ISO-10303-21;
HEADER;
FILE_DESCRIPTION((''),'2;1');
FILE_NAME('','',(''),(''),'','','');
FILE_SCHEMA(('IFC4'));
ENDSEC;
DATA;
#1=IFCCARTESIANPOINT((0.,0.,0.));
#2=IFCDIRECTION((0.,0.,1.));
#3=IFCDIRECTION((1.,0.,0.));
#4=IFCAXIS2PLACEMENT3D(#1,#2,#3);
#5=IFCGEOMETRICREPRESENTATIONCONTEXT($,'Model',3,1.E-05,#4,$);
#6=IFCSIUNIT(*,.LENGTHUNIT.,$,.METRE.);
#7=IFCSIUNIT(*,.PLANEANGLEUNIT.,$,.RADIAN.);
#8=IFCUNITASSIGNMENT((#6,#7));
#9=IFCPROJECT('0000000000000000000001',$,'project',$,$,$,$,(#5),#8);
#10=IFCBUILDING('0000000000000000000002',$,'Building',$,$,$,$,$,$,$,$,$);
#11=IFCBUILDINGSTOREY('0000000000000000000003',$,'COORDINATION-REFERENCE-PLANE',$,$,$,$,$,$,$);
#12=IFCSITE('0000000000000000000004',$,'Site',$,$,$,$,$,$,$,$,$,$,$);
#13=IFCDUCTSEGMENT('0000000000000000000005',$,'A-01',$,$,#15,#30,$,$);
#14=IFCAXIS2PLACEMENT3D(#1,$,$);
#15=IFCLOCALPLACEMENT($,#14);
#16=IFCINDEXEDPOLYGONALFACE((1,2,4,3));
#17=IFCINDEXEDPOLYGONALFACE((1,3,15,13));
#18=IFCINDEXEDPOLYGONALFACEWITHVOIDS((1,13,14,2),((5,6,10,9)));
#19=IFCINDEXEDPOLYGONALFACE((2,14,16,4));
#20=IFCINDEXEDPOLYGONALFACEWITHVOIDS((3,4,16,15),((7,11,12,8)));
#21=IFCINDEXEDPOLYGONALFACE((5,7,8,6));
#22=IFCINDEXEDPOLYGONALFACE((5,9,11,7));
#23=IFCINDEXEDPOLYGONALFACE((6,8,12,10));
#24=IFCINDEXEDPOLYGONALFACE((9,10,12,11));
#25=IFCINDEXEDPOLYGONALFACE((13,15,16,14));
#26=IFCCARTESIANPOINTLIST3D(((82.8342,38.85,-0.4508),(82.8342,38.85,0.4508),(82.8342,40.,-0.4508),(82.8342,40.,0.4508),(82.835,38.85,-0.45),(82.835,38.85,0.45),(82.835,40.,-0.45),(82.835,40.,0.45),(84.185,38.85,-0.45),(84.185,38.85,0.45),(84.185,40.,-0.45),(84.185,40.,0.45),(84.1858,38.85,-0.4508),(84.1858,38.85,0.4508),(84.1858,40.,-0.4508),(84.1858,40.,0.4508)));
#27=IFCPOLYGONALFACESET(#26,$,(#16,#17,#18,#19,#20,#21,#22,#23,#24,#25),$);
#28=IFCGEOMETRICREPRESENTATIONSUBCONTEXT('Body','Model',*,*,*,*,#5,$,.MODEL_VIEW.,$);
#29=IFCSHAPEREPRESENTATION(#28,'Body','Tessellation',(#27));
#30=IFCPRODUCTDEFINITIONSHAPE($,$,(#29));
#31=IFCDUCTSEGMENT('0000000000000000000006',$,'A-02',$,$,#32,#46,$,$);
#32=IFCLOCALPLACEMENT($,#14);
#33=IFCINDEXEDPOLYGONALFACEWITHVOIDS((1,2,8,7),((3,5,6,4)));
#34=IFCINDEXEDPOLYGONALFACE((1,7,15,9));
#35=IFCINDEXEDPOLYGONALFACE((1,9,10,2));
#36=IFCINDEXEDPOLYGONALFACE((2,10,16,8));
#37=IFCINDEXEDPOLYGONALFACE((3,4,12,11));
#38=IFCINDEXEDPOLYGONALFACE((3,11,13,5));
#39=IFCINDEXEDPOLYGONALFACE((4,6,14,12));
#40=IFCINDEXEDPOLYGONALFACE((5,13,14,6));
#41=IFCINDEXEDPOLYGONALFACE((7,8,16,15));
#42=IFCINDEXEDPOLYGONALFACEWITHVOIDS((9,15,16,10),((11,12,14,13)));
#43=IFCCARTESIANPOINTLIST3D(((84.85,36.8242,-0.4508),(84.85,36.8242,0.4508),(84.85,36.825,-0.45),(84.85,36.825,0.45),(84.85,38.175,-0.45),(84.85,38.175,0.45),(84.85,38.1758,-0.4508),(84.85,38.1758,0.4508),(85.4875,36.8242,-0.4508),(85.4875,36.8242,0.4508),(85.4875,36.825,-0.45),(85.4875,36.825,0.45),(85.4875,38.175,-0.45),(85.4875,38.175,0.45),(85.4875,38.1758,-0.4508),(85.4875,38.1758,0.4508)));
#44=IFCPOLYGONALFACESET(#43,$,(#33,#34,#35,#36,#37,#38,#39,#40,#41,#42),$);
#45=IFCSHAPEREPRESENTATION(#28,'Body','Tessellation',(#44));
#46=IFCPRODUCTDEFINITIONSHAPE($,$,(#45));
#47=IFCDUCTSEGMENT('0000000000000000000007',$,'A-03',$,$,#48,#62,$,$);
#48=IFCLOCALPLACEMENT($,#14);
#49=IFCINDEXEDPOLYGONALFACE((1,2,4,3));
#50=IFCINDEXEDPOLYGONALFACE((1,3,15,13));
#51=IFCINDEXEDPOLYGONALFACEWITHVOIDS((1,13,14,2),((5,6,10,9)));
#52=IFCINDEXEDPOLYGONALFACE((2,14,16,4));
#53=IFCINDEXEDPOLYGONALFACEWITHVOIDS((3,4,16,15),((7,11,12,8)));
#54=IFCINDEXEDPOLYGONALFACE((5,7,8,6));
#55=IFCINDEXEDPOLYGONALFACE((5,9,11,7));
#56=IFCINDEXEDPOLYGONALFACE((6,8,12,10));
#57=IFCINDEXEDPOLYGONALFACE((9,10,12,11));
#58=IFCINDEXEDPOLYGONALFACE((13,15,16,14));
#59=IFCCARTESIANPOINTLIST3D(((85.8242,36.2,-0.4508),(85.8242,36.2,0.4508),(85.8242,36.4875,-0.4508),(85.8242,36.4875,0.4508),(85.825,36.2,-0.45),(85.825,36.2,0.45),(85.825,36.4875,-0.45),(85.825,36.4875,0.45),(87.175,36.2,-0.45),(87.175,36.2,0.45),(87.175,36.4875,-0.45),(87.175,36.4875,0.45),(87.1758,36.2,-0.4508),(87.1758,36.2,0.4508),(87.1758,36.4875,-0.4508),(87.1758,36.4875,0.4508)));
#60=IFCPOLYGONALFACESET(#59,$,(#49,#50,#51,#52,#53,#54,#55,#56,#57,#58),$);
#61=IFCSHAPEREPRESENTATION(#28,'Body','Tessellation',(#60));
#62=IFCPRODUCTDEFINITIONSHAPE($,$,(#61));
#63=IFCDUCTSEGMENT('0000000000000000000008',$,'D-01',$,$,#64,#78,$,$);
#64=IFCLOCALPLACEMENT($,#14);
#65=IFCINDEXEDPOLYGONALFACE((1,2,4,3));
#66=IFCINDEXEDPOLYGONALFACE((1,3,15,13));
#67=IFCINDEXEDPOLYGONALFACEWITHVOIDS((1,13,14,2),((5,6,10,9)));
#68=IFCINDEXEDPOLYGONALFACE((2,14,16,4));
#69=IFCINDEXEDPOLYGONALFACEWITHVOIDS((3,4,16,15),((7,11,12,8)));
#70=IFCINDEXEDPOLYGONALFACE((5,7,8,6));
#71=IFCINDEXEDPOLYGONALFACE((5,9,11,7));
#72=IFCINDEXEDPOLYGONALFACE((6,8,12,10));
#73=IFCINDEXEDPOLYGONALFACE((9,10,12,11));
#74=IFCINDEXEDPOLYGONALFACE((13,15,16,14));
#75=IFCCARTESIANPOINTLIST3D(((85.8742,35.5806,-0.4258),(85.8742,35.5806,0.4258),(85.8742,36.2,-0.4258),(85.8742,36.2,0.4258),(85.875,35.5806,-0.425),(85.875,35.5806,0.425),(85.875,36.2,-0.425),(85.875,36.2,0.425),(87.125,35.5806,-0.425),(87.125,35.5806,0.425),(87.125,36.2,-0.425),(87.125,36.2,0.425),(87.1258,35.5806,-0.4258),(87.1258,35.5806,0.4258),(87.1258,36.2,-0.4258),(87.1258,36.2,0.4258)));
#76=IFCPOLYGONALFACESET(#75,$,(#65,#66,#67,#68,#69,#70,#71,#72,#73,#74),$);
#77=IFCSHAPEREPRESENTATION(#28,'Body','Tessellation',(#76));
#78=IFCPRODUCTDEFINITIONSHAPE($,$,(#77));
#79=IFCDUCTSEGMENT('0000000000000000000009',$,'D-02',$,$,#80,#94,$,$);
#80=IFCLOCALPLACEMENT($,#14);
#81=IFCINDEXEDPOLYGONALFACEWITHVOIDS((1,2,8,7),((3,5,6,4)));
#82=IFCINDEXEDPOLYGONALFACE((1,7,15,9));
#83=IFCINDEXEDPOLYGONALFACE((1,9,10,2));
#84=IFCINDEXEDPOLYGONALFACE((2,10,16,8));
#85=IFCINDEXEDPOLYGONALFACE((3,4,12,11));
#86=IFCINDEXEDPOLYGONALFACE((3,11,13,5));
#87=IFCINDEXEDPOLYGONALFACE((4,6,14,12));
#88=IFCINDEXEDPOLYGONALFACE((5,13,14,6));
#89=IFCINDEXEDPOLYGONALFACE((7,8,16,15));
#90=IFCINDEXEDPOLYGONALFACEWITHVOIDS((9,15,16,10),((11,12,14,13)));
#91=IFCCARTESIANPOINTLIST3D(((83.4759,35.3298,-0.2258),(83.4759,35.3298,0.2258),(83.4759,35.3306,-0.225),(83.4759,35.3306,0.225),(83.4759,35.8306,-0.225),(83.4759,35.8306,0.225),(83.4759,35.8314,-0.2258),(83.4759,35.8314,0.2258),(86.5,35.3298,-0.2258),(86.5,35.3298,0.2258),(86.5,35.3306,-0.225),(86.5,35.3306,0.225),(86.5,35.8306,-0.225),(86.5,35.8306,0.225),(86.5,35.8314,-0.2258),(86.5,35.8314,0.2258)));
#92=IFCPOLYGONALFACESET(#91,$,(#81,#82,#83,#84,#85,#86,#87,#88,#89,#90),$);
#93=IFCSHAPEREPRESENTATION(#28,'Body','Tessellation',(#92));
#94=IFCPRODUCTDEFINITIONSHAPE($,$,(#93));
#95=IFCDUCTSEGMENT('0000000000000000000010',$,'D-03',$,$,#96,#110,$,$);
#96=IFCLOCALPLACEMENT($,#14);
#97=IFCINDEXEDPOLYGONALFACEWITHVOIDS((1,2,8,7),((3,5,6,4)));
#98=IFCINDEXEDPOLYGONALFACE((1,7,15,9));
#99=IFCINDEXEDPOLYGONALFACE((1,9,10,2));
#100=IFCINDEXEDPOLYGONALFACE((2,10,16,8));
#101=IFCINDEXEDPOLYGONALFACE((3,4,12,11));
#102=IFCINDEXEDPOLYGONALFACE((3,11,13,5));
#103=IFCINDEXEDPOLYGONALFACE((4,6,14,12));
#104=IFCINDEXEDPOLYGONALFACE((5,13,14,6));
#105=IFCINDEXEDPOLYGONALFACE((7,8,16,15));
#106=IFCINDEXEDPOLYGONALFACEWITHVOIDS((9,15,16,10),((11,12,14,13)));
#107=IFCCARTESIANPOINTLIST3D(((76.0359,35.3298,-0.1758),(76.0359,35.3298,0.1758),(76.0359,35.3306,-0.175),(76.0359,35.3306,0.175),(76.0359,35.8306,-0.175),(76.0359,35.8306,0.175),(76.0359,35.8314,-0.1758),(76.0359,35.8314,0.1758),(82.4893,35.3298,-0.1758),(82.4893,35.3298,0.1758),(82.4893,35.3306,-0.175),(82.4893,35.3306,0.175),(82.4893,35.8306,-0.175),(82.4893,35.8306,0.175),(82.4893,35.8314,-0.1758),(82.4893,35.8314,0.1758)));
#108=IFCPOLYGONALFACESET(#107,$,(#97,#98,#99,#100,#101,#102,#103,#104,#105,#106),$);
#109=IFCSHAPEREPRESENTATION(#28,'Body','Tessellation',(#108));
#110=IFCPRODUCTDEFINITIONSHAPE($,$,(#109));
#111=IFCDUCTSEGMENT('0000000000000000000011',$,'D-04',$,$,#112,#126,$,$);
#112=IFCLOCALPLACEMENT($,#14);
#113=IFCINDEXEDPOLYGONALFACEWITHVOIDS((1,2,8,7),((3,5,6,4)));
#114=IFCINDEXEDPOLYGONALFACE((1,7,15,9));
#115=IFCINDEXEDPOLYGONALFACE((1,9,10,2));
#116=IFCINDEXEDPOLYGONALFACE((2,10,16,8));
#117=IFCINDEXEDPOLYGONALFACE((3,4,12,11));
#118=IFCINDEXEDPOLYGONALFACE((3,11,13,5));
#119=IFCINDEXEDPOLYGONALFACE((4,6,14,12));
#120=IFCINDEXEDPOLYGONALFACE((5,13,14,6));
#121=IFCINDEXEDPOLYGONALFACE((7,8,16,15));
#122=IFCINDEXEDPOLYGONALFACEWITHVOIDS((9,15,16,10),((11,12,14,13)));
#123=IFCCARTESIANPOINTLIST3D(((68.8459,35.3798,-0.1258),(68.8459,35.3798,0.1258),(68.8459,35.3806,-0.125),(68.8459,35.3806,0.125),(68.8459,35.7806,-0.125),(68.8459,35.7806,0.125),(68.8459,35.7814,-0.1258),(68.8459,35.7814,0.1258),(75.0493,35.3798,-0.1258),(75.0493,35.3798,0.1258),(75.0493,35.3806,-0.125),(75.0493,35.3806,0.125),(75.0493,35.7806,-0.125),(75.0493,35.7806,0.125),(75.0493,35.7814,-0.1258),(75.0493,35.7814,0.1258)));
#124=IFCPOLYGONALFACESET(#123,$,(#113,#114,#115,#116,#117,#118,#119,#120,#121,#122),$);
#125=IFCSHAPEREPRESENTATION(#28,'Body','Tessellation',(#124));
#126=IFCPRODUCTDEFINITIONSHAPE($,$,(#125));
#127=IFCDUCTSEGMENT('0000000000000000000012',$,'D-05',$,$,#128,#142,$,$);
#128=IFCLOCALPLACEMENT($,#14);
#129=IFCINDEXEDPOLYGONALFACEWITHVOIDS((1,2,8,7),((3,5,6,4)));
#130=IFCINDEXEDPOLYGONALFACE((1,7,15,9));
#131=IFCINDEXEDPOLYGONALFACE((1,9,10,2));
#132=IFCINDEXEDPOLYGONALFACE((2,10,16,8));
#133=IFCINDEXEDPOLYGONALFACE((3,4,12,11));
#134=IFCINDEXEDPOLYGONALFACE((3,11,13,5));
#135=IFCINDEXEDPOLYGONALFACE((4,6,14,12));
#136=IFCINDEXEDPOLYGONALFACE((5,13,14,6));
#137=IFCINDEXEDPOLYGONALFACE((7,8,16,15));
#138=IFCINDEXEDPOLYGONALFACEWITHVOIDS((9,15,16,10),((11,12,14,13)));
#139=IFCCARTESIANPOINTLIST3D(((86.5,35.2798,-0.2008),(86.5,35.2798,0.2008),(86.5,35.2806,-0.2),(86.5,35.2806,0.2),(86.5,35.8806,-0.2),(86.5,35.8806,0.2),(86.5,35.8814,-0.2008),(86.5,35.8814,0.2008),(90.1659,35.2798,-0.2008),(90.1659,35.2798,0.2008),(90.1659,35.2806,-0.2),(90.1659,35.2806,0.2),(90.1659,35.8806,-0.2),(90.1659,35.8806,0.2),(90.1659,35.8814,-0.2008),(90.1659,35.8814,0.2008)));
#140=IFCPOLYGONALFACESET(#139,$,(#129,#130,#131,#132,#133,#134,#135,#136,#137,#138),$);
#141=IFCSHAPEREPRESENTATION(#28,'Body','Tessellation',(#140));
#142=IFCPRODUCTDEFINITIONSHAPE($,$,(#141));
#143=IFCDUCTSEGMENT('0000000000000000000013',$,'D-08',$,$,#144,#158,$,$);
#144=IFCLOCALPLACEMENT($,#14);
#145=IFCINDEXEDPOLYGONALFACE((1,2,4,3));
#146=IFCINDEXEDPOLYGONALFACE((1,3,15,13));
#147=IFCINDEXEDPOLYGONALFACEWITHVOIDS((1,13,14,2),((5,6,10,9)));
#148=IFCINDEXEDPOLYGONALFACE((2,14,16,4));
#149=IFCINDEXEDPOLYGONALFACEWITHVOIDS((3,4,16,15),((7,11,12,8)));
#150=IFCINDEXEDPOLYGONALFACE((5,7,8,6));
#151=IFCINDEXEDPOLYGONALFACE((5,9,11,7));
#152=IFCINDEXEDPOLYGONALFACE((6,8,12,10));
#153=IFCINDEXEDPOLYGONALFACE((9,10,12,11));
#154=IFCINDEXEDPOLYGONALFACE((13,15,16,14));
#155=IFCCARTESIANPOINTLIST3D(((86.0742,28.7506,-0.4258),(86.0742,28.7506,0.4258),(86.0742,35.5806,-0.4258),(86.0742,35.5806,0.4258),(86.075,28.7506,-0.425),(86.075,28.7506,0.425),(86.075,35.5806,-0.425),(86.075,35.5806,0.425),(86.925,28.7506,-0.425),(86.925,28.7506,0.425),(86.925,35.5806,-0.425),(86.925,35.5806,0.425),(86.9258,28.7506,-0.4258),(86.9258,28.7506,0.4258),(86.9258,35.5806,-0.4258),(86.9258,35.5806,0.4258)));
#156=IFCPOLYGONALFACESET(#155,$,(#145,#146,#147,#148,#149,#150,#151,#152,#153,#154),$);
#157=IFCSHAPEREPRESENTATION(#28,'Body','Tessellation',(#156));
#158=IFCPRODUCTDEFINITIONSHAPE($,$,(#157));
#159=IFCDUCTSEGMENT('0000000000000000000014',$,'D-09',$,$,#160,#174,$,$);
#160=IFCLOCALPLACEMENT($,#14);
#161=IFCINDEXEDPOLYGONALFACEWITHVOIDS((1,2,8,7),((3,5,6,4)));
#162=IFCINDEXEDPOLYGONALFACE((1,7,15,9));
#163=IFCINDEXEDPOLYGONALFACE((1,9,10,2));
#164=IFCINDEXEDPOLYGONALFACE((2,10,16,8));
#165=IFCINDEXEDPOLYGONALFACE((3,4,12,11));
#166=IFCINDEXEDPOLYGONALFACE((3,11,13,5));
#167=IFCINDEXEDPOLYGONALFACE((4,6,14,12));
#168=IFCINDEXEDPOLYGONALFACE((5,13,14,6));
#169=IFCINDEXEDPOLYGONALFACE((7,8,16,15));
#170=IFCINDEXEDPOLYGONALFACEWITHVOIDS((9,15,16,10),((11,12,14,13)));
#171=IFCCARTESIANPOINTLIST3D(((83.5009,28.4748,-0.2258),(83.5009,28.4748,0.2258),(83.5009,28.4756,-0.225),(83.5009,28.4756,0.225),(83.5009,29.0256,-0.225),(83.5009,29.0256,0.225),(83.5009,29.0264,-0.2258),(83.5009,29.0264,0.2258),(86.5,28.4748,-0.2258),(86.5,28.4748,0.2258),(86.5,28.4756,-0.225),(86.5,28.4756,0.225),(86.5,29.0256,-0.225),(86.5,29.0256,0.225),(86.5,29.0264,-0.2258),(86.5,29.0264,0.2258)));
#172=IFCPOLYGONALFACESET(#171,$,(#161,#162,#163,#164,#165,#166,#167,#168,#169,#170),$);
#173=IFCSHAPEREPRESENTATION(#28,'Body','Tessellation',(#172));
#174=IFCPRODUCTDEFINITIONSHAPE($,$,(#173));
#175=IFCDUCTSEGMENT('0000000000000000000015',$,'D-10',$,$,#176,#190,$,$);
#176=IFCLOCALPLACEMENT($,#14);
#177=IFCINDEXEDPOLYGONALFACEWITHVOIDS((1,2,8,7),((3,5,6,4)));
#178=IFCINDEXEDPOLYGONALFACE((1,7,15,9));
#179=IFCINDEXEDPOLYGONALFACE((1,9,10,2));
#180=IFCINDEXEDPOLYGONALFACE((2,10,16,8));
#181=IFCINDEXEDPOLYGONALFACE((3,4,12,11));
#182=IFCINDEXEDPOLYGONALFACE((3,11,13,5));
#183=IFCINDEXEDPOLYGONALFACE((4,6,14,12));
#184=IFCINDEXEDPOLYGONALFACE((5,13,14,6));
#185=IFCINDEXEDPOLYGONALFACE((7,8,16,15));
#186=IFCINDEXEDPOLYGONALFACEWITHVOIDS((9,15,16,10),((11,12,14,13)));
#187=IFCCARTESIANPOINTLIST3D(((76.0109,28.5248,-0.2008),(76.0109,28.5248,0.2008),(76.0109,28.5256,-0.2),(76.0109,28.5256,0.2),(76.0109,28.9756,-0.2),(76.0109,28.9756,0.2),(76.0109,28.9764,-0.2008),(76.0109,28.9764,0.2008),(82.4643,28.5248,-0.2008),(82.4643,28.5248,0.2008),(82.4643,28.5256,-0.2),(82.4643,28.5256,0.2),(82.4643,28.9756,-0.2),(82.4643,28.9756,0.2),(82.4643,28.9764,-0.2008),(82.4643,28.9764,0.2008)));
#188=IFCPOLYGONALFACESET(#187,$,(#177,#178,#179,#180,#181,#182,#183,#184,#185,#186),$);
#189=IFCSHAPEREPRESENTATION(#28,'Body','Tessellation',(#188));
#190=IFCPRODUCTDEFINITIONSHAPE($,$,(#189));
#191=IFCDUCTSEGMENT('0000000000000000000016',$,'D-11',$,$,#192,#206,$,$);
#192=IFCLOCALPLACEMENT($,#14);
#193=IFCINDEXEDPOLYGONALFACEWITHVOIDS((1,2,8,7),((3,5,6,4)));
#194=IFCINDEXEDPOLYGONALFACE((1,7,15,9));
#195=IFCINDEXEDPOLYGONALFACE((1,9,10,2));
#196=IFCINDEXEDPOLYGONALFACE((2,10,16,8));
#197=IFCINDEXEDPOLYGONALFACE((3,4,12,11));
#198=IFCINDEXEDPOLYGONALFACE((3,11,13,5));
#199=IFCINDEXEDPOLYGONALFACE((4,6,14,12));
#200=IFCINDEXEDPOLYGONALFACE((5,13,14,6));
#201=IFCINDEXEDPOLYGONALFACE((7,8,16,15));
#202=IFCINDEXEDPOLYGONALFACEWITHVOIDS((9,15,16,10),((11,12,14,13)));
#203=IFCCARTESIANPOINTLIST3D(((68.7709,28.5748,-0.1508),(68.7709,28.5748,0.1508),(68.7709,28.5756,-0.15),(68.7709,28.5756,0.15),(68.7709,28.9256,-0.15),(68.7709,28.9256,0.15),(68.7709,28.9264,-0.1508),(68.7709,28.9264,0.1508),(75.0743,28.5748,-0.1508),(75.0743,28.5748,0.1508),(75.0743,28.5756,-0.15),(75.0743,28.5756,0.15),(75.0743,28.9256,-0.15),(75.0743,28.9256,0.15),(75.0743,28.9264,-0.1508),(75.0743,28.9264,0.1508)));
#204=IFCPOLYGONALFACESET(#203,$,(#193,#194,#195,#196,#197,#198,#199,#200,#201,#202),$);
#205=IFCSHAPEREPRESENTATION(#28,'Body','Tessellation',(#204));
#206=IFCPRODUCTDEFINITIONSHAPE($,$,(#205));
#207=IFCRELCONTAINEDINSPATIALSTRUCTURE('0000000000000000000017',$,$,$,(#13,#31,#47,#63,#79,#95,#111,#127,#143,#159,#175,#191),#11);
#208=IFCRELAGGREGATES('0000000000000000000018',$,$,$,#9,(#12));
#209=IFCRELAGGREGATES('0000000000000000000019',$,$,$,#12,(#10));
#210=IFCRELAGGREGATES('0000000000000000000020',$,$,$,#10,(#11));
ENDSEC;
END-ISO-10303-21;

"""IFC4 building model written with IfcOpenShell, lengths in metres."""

from ifc_helpers import new_model, si_unit, frame, origin, origin_with_axes, place, context, subcontext, project, spatial, hollow_rectangle, extrude, element, save


model = new_model("IFC4")

# Units and contexts
model_context = context("Model", 3, precision=1e-05, world=origin_with_axes())
body_context = subcontext(model_context, "Body", "Model", "MODEL_VIEW")
ifc_project = project(units=[si_unit("LENGTHUNIT", "METRE"), si_unit("PLANEANGLEUNIT", "RADIAN")], contexts=[model_context])

# Site, building, storey
site = spatial("IfcSite", under=ifc_project, Name="Site")
building = spatial("IfcBuilding", under=site, Name="Building")
storey = spatial("IfcBuildingStorey", under=building, Name="COORDINATION-REFERENCE-PLANE")

# Duct segments
duct_segment_1_placement = place(None, frame((83.51, 38.85, 0.0), z_axis=(0.0, 1.0, 0.0), x_axis=(1.0, 0.0, 0.0)))
element("IfcDuctSegment", 1, at=duct_segment_1_placement, inside=storey, Name="A-01", context=body_context, shape_type="SweptSolid", body=[
    extrude(hollow_rectangle(XDim=1.3516, YDim=0.9016, WallThickness=0.0008), origin(), (0.0, 0.0, 1.0), 1.15),
])
duct_segment_2_placement = place(None, frame((84.85, 37.5, 0.0), z_axis=(1.0, 0.0, 0.0), x_axis=(0.0, 1.0, 0.0)))
element("IfcDuctSegment", 2, at=duct_segment_2_placement, inside=storey, Name="A-02", context=body_context, shape_type="SweptSolid", body=[
    extrude(hollow_rectangle(XDim=1.3516, YDim=0.9016, WallThickness=0.0008), origin(), (0.0, 0.0, 1.0), 0.6375),
])
duct_segment_3_placement = place(None, frame((86.5, 36.2, 0.0), z_axis=(0.0, 1.0, 0.0), x_axis=(1.0, 0.0, 0.0)))
element("IfcDuctSegment", 3, at=duct_segment_3_placement, inside=storey, Name="A-03", context=body_context, shape_type="SweptSolid", body=[
    extrude(hollow_rectangle(XDim=1.3516, YDim=0.9016, WallThickness=0.0008), origin(), (0.0, 0.0, 1.0), 0.2875),
])
duct_segment_4_placement = place(None, frame((86.5, 35.5806, 0.0), z_axis=(0.0, 1.0, 0.0), x_axis=(1.0, 0.0, 0.0)))
element("IfcDuctSegment", 4, at=duct_segment_4_placement, inside=storey, Name="D-01", context=body_context, shape_type="SweptSolid", body=[
    extrude(hollow_rectangle(XDim=1.2516, YDim=0.8516, WallThickness=0.0008), origin(), (0.0, 0.0, 1.0), 0.6194),
])
duct_segment_5_placement = place(None, frame((83.4759, 35.5806, 0.0), z_axis=(1.0, 0.0, 0.0), x_axis=(0.0, 1.0, 0.0)))
element("IfcDuctSegment", 5, at=duct_segment_5_placement, inside=storey, Name="D-02", context=body_context, shape_type="SweptSolid", body=[
    extrude(hollow_rectangle(XDim=0.5016, YDim=0.4516, WallThickness=0.0008), origin(), (0.0, 0.0, 1.0), 3.0241),
])
duct_segment_6_placement = place(None, frame((76.0359, 35.5806, 0.0), z_axis=(1.0, 0.0, 0.0), x_axis=(0.0, 1.0, 0.0)))
element("IfcDuctSegment", 6, at=duct_segment_6_placement, inside=storey, Name="D-03", context=body_context, shape_type="SweptSolid", body=[
    extrude(hollow_rectangle(XDim=0.5016, YDim=0.3516, WallThickness=0.0008), origin(), (0.0, 0.0, 1.0), 6.4534),
])
duct_segment_7_placement = place(None, frame((68.8459, 35.5806, 0.0), z_axis=(1.0, 0.0, 0.0), x_axis=(0.0, 1.0, 0.0)))
element("IfcDuctSegment", 7, at=duct_segment_7_placement, inside=storey, Name="D-04", context=body_context, shape_type="SweptSolid", body=[
    extrude(hollow_rectangle(XDim=0.4016, YDim=0.2516, WallThickness=0.0008), origin(), (0.0, 0.0, 1.0), 6.2034),
])
duct_segment_8_placement = place(None, frame((86.5, 35.5806, 0.0), z_axis=(1.0, 0.0, 0.0), x_axis=(0.0, 1.0, 0.0)))
element("IfcDuctSegment", 8, at=duct_segment_8_placement, inside=storey, Name="D-05", context=body_context, shape_type="SweptSolid", body=[
    extrude(hollow_rectangle(XDim=0.6016, YDim=0.4016, WallThickness=0.0008), origin(), (0.0, 0.0, 1.0), 3.6659),
])
duct_segment_9_placement = place(None, frame((86.5, 28.7506, 0.0), z_axis=(0.0, 1.0, 0.0), x_axis=(1.0, 0.0, 0.0)))
element("IfcDuctSegment", 9, at=duct_segment_9_placement, inside=storey, Name="D-08", context=body_context, shape_type="SweptSolid", body=[
    extrude(hollow_rectangle(XDim=0.8516, YDim=0.8516, WallThickness=0.0008), origin(), (0.0, 0.0, 1.0), 6.83),
])
duct_segment_10_placement = place(None, frame((83.5009, 28.7506, 0.0), z_axis=(1.0, 0.0, 0.0), x_axis=(0.0, 1.0, 0.0)))
element("IfcDuctSegment", 10, at=duct_segment_10_placement, inside=storey, Name="D-09", context=body_context, shape_type="SweptSolid", body=[
    extrude(hollow_rectangle(XDim=0.5516, YDim=0.4516, WallThickness=0.0008), origin(), (0.0, 0.0, 1.0), 2.9991),
])
duct_segment_11_placement = place(None, frame((76.0109, 28.7506, 0.0), z_axis=(1.0, 0.0, 0.0), x_axis=(0.0, 1.0, 0.0)))
element("IfcDuctSegment", 11, at=duct_segment_11_placement, inside=storey, Name="D-10", context=body_context, shape_type="SweptSolid", body=[
    extrude(hollow_rectangle(XDim=0.4516, YDim=0.4016, WallThickness=0.0008), origin(), (0.0, 0.0, 1.0), 6.4534),
])
duct_segment_12_placement = place(None, frame((68.7709, 28.7506, 0.0), z_axis=(1.0, 0.0, 0.0), x_axis=(0.0, 1.0, 0.0)))
element("IfcDuctSegment", 12, at=duct_segment_12_placement, inside=storey, Name="D-11", context=body_context, shape_type="SweptSolid", body=[
    extrude(hollow_rectangle(XDim=0.3516, YDim=0.3016, WallThickness=0.0008), origin(), (0.0, 0.0, 1.0), 6.3034),
])

save(model, "model.ifc")
